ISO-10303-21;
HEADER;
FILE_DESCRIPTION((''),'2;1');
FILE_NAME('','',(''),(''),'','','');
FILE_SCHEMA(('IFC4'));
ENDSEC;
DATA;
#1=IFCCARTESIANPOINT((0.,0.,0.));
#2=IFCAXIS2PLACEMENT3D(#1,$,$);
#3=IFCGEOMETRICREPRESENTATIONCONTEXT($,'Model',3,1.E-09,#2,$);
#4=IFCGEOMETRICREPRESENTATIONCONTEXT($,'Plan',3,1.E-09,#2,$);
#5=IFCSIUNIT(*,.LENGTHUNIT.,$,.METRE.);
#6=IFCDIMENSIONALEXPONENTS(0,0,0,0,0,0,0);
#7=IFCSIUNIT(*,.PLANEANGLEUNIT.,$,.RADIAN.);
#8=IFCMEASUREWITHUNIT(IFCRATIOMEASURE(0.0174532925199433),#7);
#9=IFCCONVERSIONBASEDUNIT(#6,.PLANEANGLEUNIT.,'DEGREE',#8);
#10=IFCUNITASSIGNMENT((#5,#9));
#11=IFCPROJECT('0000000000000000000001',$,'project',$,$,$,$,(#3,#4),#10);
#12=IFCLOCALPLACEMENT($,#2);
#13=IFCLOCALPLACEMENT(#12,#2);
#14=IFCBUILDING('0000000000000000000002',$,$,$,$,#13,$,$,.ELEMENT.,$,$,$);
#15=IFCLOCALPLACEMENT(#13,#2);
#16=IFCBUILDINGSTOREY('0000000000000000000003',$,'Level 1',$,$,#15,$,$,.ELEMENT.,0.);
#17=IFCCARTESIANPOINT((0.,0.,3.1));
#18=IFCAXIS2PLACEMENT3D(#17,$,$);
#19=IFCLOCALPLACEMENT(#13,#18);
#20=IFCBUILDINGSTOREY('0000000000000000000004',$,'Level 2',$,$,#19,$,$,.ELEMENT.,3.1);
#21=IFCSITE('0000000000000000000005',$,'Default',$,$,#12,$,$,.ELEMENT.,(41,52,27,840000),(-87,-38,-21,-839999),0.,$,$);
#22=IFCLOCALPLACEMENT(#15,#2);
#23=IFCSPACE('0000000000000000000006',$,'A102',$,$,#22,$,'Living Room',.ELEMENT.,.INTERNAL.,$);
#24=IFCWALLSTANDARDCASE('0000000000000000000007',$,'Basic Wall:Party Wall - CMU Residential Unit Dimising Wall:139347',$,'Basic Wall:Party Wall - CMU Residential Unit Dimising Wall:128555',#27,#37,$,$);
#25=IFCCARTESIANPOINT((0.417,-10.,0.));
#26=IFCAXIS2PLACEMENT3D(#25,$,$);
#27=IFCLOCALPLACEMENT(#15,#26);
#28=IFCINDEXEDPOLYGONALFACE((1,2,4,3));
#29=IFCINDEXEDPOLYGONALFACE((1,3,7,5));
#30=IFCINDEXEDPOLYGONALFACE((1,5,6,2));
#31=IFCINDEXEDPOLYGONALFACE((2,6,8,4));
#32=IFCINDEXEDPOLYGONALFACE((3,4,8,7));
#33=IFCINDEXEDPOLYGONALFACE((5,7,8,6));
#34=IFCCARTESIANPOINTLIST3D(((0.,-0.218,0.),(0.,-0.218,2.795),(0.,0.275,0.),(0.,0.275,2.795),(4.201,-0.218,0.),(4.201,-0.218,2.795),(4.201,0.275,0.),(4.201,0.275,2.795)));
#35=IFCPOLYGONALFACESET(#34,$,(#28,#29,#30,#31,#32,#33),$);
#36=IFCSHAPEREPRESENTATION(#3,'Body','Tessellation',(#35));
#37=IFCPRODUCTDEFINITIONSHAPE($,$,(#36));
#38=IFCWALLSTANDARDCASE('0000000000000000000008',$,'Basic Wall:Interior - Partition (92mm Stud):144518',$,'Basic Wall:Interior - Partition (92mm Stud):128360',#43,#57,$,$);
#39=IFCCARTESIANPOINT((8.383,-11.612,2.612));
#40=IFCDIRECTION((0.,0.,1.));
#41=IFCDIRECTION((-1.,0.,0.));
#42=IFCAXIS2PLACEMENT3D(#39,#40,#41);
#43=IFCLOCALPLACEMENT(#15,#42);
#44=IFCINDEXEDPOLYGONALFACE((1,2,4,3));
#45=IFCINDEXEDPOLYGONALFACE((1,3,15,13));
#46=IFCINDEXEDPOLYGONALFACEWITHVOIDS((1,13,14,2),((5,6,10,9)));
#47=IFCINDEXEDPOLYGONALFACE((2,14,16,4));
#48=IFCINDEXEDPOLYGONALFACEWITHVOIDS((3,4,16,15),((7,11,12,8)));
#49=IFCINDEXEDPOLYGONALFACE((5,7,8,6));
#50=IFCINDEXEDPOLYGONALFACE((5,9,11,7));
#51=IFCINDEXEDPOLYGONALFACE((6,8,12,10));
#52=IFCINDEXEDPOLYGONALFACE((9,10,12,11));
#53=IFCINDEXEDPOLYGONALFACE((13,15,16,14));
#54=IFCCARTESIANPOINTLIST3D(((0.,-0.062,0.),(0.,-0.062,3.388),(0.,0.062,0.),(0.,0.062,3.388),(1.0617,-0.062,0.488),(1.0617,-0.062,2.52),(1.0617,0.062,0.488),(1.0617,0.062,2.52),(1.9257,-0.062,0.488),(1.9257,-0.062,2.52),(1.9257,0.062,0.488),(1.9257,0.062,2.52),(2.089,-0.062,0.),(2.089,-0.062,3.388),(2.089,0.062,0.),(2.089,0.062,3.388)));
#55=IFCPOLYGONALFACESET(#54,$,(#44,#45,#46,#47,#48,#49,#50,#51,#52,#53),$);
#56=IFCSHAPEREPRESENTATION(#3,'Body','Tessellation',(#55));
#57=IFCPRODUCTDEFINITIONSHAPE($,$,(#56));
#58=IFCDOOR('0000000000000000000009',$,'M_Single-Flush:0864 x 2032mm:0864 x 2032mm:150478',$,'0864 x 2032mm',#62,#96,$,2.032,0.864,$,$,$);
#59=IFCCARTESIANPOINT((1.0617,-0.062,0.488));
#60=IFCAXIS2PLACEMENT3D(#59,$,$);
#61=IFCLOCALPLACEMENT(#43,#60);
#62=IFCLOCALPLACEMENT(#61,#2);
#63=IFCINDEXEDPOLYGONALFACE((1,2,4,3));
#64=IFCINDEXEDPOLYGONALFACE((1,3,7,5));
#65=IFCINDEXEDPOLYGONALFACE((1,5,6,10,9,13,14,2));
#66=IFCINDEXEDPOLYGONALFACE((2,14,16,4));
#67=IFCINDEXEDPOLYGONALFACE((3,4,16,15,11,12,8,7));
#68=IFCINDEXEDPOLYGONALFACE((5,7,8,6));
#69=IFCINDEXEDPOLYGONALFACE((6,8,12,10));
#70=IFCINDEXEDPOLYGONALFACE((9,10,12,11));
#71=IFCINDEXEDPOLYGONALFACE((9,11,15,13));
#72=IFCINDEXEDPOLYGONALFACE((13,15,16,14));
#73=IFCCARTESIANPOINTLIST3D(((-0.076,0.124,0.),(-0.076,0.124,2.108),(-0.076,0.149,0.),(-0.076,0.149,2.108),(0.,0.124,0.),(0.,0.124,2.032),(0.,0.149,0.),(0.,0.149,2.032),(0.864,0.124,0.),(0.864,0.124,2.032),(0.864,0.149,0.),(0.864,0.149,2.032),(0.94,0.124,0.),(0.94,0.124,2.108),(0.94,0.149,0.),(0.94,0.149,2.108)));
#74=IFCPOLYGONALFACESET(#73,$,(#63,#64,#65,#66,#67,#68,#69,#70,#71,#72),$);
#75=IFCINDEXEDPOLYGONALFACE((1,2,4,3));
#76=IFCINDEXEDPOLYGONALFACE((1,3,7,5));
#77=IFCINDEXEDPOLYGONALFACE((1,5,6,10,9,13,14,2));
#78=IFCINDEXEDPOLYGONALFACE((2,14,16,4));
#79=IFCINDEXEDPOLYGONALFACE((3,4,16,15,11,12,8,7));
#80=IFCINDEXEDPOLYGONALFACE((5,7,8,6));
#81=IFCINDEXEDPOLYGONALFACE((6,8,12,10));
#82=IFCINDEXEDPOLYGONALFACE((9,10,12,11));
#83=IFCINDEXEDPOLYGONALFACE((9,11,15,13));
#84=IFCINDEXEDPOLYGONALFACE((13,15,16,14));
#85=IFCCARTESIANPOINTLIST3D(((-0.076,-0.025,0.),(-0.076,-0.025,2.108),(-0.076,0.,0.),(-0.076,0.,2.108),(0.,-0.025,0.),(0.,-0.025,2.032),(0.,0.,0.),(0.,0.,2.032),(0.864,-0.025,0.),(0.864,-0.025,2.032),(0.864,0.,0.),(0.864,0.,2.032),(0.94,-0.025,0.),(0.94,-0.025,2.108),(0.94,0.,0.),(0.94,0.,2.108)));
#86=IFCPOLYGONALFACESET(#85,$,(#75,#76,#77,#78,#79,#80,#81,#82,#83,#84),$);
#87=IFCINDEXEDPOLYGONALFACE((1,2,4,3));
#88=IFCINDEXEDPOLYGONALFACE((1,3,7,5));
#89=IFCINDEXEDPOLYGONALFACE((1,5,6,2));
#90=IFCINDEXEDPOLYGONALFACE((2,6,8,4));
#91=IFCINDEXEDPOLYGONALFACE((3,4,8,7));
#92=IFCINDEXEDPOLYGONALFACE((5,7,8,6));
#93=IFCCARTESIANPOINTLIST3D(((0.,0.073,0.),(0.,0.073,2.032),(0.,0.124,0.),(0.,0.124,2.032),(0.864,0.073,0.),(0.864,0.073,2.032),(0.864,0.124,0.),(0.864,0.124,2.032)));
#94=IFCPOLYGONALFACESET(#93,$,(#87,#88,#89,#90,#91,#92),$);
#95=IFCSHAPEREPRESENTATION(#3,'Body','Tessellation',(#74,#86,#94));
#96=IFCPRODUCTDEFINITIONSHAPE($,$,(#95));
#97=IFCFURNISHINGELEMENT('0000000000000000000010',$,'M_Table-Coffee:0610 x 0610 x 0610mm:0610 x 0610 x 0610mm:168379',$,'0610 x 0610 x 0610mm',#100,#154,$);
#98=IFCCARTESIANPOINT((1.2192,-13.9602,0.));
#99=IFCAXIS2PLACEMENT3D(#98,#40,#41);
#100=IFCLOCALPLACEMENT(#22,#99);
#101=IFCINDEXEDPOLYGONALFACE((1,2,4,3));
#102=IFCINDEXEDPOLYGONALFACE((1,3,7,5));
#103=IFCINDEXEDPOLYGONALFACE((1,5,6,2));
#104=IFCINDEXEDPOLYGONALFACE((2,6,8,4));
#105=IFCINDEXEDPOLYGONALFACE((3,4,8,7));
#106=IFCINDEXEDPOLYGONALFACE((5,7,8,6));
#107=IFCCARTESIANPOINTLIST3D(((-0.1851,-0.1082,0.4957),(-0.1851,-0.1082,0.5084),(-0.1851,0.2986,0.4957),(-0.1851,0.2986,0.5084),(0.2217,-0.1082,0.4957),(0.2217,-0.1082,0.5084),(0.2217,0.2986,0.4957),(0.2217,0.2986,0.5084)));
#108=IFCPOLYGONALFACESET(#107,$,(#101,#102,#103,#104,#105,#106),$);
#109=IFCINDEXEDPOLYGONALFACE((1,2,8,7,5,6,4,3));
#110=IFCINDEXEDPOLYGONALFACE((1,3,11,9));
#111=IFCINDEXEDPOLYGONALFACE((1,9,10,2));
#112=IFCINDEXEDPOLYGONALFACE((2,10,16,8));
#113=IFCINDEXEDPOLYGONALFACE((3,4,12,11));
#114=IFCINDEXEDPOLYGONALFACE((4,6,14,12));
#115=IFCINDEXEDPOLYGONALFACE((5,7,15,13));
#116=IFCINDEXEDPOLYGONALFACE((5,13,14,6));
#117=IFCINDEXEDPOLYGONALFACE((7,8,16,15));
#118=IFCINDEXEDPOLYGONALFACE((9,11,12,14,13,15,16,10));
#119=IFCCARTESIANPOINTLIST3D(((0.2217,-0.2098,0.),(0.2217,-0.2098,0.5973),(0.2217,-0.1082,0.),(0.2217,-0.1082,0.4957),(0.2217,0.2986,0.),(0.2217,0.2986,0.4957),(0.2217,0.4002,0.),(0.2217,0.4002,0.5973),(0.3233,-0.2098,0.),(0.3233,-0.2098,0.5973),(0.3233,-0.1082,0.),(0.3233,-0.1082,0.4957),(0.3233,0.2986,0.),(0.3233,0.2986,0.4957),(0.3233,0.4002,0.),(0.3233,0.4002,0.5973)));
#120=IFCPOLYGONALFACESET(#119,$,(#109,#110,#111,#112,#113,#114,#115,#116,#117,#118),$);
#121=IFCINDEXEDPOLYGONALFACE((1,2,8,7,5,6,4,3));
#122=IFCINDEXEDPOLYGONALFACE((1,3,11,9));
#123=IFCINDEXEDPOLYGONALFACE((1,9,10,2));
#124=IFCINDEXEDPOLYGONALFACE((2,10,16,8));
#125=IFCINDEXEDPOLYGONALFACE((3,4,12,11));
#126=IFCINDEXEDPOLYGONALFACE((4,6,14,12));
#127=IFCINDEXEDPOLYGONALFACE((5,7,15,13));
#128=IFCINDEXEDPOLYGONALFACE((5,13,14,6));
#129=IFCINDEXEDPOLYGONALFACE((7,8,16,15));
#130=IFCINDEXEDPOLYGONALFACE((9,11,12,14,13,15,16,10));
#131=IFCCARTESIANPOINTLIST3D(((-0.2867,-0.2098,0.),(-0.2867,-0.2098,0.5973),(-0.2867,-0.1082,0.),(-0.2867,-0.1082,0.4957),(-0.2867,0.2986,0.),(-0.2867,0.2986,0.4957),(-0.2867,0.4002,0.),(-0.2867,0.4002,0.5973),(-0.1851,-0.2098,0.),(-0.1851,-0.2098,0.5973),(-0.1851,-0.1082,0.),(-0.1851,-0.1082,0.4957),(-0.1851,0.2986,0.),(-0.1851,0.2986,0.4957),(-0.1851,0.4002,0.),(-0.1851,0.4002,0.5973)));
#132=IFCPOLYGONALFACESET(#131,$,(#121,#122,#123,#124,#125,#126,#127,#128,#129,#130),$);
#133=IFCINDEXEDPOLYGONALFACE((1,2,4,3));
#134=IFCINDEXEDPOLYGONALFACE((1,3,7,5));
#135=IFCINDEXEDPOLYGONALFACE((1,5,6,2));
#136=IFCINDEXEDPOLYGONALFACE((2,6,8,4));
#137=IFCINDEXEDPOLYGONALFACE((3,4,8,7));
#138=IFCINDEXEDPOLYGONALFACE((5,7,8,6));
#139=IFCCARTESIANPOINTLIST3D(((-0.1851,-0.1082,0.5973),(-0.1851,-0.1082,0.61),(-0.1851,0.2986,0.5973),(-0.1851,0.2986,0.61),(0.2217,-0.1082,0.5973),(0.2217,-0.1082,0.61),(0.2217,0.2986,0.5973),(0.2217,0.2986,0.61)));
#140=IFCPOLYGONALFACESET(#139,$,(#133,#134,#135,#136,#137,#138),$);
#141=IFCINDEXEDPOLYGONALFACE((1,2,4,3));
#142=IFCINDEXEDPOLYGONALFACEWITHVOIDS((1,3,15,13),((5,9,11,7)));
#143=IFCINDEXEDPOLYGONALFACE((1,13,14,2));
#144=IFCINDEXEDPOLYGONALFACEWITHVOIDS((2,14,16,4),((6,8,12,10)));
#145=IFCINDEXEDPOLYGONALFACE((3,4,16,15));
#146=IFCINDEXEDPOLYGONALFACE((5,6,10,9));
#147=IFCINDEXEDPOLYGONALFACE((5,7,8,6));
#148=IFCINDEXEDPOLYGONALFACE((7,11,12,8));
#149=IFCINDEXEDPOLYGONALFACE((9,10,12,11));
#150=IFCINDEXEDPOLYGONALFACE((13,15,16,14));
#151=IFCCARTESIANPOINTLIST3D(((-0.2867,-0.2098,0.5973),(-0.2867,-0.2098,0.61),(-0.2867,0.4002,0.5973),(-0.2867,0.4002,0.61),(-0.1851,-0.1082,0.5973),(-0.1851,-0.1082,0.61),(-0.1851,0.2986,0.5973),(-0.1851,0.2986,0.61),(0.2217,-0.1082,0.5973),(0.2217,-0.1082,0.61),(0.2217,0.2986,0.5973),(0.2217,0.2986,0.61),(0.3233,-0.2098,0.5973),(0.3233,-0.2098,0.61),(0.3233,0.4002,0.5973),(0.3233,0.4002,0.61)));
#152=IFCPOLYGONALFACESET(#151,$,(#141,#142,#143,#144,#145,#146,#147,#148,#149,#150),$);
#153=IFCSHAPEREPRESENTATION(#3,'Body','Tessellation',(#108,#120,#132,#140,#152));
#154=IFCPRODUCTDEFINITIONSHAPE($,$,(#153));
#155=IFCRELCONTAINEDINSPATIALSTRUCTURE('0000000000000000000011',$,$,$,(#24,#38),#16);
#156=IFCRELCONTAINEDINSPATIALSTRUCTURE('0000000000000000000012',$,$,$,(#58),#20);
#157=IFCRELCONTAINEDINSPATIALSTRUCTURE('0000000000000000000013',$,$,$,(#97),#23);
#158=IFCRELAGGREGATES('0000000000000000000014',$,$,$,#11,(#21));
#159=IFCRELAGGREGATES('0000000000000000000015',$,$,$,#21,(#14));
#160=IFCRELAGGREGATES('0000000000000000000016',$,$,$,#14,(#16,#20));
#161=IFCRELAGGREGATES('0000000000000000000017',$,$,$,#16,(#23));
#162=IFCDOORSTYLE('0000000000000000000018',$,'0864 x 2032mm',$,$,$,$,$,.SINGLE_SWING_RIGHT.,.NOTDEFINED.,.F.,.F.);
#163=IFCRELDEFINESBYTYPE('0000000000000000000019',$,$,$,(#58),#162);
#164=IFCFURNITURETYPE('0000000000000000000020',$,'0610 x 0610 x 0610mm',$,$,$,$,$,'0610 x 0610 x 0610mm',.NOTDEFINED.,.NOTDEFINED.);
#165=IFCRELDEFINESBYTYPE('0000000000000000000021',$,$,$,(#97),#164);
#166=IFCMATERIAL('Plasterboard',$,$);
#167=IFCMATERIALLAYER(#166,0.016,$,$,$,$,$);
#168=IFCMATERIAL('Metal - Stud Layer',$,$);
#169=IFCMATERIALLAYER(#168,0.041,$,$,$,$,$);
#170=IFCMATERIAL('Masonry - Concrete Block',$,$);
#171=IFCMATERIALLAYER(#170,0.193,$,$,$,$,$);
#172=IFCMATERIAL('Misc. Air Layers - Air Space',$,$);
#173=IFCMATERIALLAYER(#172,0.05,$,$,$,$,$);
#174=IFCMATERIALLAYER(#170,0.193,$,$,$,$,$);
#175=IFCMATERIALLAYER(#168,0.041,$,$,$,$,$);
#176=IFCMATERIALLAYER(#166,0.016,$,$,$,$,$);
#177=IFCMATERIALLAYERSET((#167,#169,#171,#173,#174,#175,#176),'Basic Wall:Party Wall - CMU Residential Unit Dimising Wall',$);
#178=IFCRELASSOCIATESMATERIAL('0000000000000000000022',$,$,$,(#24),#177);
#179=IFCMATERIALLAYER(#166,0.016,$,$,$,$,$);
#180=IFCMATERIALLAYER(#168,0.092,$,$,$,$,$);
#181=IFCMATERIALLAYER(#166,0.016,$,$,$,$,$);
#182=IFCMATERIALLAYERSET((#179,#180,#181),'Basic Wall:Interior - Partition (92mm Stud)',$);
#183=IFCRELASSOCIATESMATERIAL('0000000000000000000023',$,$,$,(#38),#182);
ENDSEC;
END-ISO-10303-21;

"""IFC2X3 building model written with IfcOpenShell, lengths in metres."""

from ifc_helpers import new_model, entity, si_unit, converted_unit, frame, frame_2d, origin, origin_2d_with_axis, place, context, project, spatial, polyline, rectangle, outline, extrude, clip, bounded_halfspace, source, transform, mapped, material, layer, layer_set, layer_usage, type_object, type_shapes, element, fill, save


model = new_model("IFC2X3")

# Units and contexts
model_context = context("Model", 3, precision=1e-09, world=origin())
plan_context = context("Plan", 3, precision=1e-09, world=origin())
ifc_project = project(units=[si_unit("LENGTHUNIT", "METRE"), converted_unit("PLANEANGLEUNIT", "DEGREE", entity("IfcRatioMeasure", 0.0174532925199433), si_unit("PLANEANGLEUNIT", "RADIAN"), dimensions=[0, 0, 0, 0, 0, 0, 0])], contexts=[model_context, plan_context])

# Site, building, storey
site_placement = place(None, origin())
site = spatial("IfcSite", under=ifc_project, at=site_placement, Name="Default", CompositionType="ELEMENT", RefLatitude=(41, 52, 27, 840000), RefLongitude=(-87, -38, -21, -839999), RefElevation=0.0)
building_placement = place(site_placement, origin())
building = spatial("IfcBuilding", under=site, at=building_placement, CompositionType="ELEMENT")
storey_1_placement = place(building_placement, origin())
storey_1 = spatial("IfcBuildingStorey", under=building, at=storey_1_placement, Name="Level 1", CompositionType="ELEMENT", Elevation=0.0)

# Shared definitions
ifc_material_1 = material(Name="Misc. Air Layers - Air Space")
ifc_material_2 = material(Name="Masonry - Concrete Block")
ifc_material_3 = material(Name="Metal - Stud Layer")
ifc_material_4 = material(Name="Plasterboard")

# Wall
ifc_layer_1 = layer(ifc_material_4, 0.016)
ifc_layer_2 = layer(ifc_material_3, 0.041)
ifc_layer_3 = layer(ifc_material_2, 0.193)
ifc_layer_4 = layer(ifc_material_1, 0.05)
ifc_layer_5 = layer(ifc_material_2, 0.193)
ifc_layer_6 = layer(ifc_material_3, 0.041)
ifc_layer_7 = layer(ifc_material_4, 0.016)
ifc_layer_set_1 = layer_set([ifc_layer_1, ifc_layer_2, ifc_layer_3, ifc_layer_4, ifc_layer_5, ifc_layer_6, ifc_layer_7], Name="Basic Wall:Party Wall - CMU Residential Unit Dimising Wall")
ifc_layer_usage_1 = layer_usage(ifc_layer_set_1, "AXIS2", "NEGATIVE", 0.275)
wall_1_placement = place(storey_1_placement, frame((0.417, -10.0, 0.0)))
element("IfcWallStandardCase", 1, at=wall_1_placement, inside=storey_1, material=ifc_layer_usage_1, Name="Basic Wall:Party Wall - CMU Residential Unit Dimising Wall:139347", ObjectType="Basic Wall:Party Wall - CMU Residential Unit Dimising Wall:128555", context=model_context, shape_type="Clipping", body=[
    clip(clip(extrude(rectangle(XDim=4.201, YDim=0.55, at=frame_2d((2.1005, 0.0), x_axis=(-1.0, 0.0))), origin(), (0.0, 0.0, 1.0), 2.795), bounded_halfspace(frame((0.0, -0.218, 0.0), z_axis=(0.0, 1.0, 0.0), x_axis=(-1.0, 0.0, 0.0)), True, frame((0.0, -0.218, 0.0), z_axis=(0.0, 1.0, 0.0), x_axis=(-1.0, 0.0, 0.0)), polyline([(0.0, 0.0), (0.0, 2.795), (-4.201, 2.795), (-4.201, 0.0), (0.0, 0.0)]))), bounded_halfspace(frame((4.201, 0.275, 0.0), z_axis=(-1.0, 0.0, 0.0), x_axis=(0.0, -1.0, 0.0)), True, frame((4.201, 0.275, 0.0), z_axis=(-1.0, 0.0, 0.0), x_axis=(0.0, -1.0, 0.0)), polyline([(0.0, 0.0), (0.493, 0.0), (0.493, 2.795), (0.0, 2.795), (0.0, 0.0)]))),
])

# Shared definitions
ifc_layer_8 = layer(ifc_material_4, 0.016)
ifc_layer_9 = layer(ifc_material_3, 0.092)
ifc_layer_10 = layer(ifc_material_4, 0.016)
ifc_layer_set_2 = layer_set([ifc_layer_8, ifc_layer_9, ifc_layer_10], Name="Basic Wall:Interior - Partition (92mm Stud)")

# Wall, opening
ifc_layer_usage_2 = layer_usage(ifc_layer_set_2, "AXIS2", "NEGATIVE", 0.062)
wall_2_placement = place(storey_1_placement, frame((8.383, -11.612, 2.612), z_axis=(0.0, 0.0, 1.0), x_axis=(-1.0, 0.0, 0.0)))
wall_2 = element("IfcWallStandardCase", 2, at=wall_2_placement, inside=storey_1, material=ifc_layer_usage_2, Name="Basic Wall:Interior - Partition (92mm Stud):144518", ObjectType="Basic Wall:Interior - Partition (92mm Stud):128360", context=model_context, shape_type="SweptSolid", body=[
    extrude(rectangle(XDim=2.089, YDim=0.124, at=frame_2d((1.0445, 0.0), x_axis=(-1.0, 0.0))), origin(), (0.0, 0.0, 1.0), 3.388),
])
opening_1_placement = place(wall_2_placement, frame((1.0617, -0.062, 0.488)))
opening_1 = element("IfcOpeningElement", 3, at=opening_1_placement, cuts=wall_2, ObjectType="Opening", context=model_context, shape_type="SweptSolid", body=[
    extrude(rectangle(XDim=0.864, YDim=2.032, at=frame_2d((1.016, 0.432), x_axis=(0.0, 1.0))), frame((0.0, 0.0, 0.0), z_axis=(0.0, 1.0, 0.0), x_axis=(0.0, 0.0, 1.0)), (0.0, 0.0, 1.0), 0.124),
])

# Shared definitions
storey_2_placement = place(building_placement, frame((0.0, 0.0, 3.1)))
storey_2 = spatial("IfcBuildingStorey", under=building, at=storey_2_placement, Name="Level 2", CompositionType="ELEMENT", Elevation=3.1)

# Door
door_style_1 = type_object("IfcDoorStyle", Name="0864 x 2032mm", ConstructionType="NOTDEFINED", OperationType="SINGLE_SWING_RIGHT", ParameterTakesPrecedence=False, Sizeable=False)
shared_shape_1 = source(origin(), model_context, "Body", "SweptSolid", [
    extrude(outline(polyline([(-0.508, -1.073), (0.508, -1.073), (0.508, 1.035), (0.432, 1.035), (0.432, -0.997), (-0.432, -0.997), (-0.432, 1.035), (-0.508, 1.035), (-0.508, -1.073)])), frame((0.432, 0.124, 1.035), z_axis=(0.0, 1.0, 0.0), x_axis=(1.0, 0.0, 0.0)), (0.0, 0.0, 1.0), 0.025),
    extrude(outline(polyline([(-1.073, -0.508), (1.035, -0.508), (1.035, -0.432), (-0.997, -0.432), (-0.997, 0.432), (1.035, 0.432), (1.035, 0.508), (-1.073, 0.508), (-1.073, -0.508)])), frame((0.432, -0.025, 1.035), z_axis=(0.0, 1.0, 0.0), x_axis=(0.0, 0.0, -1.0)), (0.0, 0.0, 1.0), 0.025),
    extrude(rectangle(XDim=0.051, YDim=0.864, at=origin_2d_with_axis()), frame((0.432, 0.0985, 0.0), z_axis=(0.0, 0.0, 1.0), x_axis=(0.0, 1.0, 0.0)), (0.0, 0.0, 1.0), 2.032),
])
type_shapes(door_style_1, [shared_shape_1])
door_1_placement = place(opening_1_placement, origin())
door_1 = element("IfcDoor", 4, at=door_1_placement, inside=storey_2, type_object=door_style_1, Name="M_Single-Flush:0864 x 2032mm:0864 x 2032mm:150478", ObjectType="0864 x 2032mm", OverallHeight=2.032, OverallWidth=0.864, context=model_context, shape_type="MappedRepresentation", body=[
    mapped(shared_shape_1, transform((0.0, 0.0, 0.0), scale=1.0)),
])
fill(opening_1, door_1)

# Shared definitions
space_1_placement = place(storey_1_placement, origin())
space_1 = spatial("IfcSpace", under=storey_1, at=space_1_placement, Name="A102", LongName="Living Room", CompositionType="ELEMENT", InteriorOrExteriorSpace="INTERNAL")

# Furnishing element
furniture_type_1 = type_object("IfcFurnitureType", Name="0610 x 0610 x 0610mm", ElementType="0610 x 0610 x 0610mm", AssemblyPlace="NOTDEFINED")
shared_shape_2 = source(origin(), model_context, "Body", "SweptSolid", [
    extrude(rectangle(XDim=0.4068, YDim=0.4068, at=origin_2d_with_axis()), frame((0.0183, 0.0952, 0.4957), z_axis=(0.0, 0.0, 1.0), x_axis=(-1.0, 0.0, 0.0)), (0.0, 0.0, 1.0), 0.0127),
    extrude(outline(polyline([(-0.2732, -0.305), (0.324, -0.305), (0.324, 0.305), (-0.2732, 0.305), (-0.2732, 0.2034), (0.2225, 0.2034), (0.2225, -0.2034), (-0.2732, -0.2034), (-0.2732, -0.305)])), frame((0.2217, 0.0952, 0.2732), z_axis=(1.0, 0.0, 0.0), x_axis=(0.0, 0.0, 1.0)), (0.0, 0.0, 1.0), 0.1016),
    extrude(outline(polyline([(-0.305, -0.3241), (0.305, -0.3241), (0.305, 0.2733), (0.2034, 0.2733), (0.2034, -0.2224), (-0.2034, -0.2224), (-0.2034, 0.2733), (-0.305, 0.2733), (-0.305, -0.3241)])), frame((-0.2867, 0.0952, 0.2733), z_axis=(1.0, 0.0, 0.0), x_axis=(0.0, -1.0, 0.0)), (0.0, 0.0, 1.0), 0.1016),
    extrude(rectangle(XDim=0.4068, YDim=0.4068, at=origin_2d_with_axis()), frame((0.0183, 0.0952, 0.5973), z_axis=(0.0, 0.0, 1.0), x_axis=(-1.0, 0.0, 0.0)), (0.0, 0.0, 1.0), 0.0127),
    extrude(outline(polyline([(-0.305, -0.305), (0.305, -0.305), (0.305, 0.305), (-0.305, 0.305), (-0.305, -0.305)]), holes=[polyline([(-0.2034, -0.2034), (-0.2034, 0.2034), (0.2034, 0.2034), (0.2034, -0.2034), (-0.2034, -0.2034)])]), frame((0.0183, 0.0952, 0.5973), z_axis=(0.0, 0.0, 1.0), x_axis=(-1.0, 0.0, 0.0)), (0.0, 0.0, 1.0), 0.0127),
])
type_shapes(furniture_type_1, [shared_shape_2])
for number, where, z_axis, x_axis, name in (
    (5, (1.2192, -13.9602, 0.0), (0.0, 0.0, 1.0), (-1.0, 0.0, 0.0), "M_Table-Coffee:0610 x 0610 x 0610mm:0610 x 0610 x 0610mm:168379"),
):
    element("IfcFurnishingElement", number, at=place(space_1_placement, frame(where, z_axis=z_axis, x_axis=x_axis)), inside=space_1, type_object=furniture_type_1, Name=name, ObjectType="0610 x 0610 x 0610mm", context=model_context, shape_type="MappedRepresentation", body=[
        mapped(shared_shape_2, transform((0.0, 0.0, 0.0), scale=1.0)),
    ])

save(model, "model.ifc")
